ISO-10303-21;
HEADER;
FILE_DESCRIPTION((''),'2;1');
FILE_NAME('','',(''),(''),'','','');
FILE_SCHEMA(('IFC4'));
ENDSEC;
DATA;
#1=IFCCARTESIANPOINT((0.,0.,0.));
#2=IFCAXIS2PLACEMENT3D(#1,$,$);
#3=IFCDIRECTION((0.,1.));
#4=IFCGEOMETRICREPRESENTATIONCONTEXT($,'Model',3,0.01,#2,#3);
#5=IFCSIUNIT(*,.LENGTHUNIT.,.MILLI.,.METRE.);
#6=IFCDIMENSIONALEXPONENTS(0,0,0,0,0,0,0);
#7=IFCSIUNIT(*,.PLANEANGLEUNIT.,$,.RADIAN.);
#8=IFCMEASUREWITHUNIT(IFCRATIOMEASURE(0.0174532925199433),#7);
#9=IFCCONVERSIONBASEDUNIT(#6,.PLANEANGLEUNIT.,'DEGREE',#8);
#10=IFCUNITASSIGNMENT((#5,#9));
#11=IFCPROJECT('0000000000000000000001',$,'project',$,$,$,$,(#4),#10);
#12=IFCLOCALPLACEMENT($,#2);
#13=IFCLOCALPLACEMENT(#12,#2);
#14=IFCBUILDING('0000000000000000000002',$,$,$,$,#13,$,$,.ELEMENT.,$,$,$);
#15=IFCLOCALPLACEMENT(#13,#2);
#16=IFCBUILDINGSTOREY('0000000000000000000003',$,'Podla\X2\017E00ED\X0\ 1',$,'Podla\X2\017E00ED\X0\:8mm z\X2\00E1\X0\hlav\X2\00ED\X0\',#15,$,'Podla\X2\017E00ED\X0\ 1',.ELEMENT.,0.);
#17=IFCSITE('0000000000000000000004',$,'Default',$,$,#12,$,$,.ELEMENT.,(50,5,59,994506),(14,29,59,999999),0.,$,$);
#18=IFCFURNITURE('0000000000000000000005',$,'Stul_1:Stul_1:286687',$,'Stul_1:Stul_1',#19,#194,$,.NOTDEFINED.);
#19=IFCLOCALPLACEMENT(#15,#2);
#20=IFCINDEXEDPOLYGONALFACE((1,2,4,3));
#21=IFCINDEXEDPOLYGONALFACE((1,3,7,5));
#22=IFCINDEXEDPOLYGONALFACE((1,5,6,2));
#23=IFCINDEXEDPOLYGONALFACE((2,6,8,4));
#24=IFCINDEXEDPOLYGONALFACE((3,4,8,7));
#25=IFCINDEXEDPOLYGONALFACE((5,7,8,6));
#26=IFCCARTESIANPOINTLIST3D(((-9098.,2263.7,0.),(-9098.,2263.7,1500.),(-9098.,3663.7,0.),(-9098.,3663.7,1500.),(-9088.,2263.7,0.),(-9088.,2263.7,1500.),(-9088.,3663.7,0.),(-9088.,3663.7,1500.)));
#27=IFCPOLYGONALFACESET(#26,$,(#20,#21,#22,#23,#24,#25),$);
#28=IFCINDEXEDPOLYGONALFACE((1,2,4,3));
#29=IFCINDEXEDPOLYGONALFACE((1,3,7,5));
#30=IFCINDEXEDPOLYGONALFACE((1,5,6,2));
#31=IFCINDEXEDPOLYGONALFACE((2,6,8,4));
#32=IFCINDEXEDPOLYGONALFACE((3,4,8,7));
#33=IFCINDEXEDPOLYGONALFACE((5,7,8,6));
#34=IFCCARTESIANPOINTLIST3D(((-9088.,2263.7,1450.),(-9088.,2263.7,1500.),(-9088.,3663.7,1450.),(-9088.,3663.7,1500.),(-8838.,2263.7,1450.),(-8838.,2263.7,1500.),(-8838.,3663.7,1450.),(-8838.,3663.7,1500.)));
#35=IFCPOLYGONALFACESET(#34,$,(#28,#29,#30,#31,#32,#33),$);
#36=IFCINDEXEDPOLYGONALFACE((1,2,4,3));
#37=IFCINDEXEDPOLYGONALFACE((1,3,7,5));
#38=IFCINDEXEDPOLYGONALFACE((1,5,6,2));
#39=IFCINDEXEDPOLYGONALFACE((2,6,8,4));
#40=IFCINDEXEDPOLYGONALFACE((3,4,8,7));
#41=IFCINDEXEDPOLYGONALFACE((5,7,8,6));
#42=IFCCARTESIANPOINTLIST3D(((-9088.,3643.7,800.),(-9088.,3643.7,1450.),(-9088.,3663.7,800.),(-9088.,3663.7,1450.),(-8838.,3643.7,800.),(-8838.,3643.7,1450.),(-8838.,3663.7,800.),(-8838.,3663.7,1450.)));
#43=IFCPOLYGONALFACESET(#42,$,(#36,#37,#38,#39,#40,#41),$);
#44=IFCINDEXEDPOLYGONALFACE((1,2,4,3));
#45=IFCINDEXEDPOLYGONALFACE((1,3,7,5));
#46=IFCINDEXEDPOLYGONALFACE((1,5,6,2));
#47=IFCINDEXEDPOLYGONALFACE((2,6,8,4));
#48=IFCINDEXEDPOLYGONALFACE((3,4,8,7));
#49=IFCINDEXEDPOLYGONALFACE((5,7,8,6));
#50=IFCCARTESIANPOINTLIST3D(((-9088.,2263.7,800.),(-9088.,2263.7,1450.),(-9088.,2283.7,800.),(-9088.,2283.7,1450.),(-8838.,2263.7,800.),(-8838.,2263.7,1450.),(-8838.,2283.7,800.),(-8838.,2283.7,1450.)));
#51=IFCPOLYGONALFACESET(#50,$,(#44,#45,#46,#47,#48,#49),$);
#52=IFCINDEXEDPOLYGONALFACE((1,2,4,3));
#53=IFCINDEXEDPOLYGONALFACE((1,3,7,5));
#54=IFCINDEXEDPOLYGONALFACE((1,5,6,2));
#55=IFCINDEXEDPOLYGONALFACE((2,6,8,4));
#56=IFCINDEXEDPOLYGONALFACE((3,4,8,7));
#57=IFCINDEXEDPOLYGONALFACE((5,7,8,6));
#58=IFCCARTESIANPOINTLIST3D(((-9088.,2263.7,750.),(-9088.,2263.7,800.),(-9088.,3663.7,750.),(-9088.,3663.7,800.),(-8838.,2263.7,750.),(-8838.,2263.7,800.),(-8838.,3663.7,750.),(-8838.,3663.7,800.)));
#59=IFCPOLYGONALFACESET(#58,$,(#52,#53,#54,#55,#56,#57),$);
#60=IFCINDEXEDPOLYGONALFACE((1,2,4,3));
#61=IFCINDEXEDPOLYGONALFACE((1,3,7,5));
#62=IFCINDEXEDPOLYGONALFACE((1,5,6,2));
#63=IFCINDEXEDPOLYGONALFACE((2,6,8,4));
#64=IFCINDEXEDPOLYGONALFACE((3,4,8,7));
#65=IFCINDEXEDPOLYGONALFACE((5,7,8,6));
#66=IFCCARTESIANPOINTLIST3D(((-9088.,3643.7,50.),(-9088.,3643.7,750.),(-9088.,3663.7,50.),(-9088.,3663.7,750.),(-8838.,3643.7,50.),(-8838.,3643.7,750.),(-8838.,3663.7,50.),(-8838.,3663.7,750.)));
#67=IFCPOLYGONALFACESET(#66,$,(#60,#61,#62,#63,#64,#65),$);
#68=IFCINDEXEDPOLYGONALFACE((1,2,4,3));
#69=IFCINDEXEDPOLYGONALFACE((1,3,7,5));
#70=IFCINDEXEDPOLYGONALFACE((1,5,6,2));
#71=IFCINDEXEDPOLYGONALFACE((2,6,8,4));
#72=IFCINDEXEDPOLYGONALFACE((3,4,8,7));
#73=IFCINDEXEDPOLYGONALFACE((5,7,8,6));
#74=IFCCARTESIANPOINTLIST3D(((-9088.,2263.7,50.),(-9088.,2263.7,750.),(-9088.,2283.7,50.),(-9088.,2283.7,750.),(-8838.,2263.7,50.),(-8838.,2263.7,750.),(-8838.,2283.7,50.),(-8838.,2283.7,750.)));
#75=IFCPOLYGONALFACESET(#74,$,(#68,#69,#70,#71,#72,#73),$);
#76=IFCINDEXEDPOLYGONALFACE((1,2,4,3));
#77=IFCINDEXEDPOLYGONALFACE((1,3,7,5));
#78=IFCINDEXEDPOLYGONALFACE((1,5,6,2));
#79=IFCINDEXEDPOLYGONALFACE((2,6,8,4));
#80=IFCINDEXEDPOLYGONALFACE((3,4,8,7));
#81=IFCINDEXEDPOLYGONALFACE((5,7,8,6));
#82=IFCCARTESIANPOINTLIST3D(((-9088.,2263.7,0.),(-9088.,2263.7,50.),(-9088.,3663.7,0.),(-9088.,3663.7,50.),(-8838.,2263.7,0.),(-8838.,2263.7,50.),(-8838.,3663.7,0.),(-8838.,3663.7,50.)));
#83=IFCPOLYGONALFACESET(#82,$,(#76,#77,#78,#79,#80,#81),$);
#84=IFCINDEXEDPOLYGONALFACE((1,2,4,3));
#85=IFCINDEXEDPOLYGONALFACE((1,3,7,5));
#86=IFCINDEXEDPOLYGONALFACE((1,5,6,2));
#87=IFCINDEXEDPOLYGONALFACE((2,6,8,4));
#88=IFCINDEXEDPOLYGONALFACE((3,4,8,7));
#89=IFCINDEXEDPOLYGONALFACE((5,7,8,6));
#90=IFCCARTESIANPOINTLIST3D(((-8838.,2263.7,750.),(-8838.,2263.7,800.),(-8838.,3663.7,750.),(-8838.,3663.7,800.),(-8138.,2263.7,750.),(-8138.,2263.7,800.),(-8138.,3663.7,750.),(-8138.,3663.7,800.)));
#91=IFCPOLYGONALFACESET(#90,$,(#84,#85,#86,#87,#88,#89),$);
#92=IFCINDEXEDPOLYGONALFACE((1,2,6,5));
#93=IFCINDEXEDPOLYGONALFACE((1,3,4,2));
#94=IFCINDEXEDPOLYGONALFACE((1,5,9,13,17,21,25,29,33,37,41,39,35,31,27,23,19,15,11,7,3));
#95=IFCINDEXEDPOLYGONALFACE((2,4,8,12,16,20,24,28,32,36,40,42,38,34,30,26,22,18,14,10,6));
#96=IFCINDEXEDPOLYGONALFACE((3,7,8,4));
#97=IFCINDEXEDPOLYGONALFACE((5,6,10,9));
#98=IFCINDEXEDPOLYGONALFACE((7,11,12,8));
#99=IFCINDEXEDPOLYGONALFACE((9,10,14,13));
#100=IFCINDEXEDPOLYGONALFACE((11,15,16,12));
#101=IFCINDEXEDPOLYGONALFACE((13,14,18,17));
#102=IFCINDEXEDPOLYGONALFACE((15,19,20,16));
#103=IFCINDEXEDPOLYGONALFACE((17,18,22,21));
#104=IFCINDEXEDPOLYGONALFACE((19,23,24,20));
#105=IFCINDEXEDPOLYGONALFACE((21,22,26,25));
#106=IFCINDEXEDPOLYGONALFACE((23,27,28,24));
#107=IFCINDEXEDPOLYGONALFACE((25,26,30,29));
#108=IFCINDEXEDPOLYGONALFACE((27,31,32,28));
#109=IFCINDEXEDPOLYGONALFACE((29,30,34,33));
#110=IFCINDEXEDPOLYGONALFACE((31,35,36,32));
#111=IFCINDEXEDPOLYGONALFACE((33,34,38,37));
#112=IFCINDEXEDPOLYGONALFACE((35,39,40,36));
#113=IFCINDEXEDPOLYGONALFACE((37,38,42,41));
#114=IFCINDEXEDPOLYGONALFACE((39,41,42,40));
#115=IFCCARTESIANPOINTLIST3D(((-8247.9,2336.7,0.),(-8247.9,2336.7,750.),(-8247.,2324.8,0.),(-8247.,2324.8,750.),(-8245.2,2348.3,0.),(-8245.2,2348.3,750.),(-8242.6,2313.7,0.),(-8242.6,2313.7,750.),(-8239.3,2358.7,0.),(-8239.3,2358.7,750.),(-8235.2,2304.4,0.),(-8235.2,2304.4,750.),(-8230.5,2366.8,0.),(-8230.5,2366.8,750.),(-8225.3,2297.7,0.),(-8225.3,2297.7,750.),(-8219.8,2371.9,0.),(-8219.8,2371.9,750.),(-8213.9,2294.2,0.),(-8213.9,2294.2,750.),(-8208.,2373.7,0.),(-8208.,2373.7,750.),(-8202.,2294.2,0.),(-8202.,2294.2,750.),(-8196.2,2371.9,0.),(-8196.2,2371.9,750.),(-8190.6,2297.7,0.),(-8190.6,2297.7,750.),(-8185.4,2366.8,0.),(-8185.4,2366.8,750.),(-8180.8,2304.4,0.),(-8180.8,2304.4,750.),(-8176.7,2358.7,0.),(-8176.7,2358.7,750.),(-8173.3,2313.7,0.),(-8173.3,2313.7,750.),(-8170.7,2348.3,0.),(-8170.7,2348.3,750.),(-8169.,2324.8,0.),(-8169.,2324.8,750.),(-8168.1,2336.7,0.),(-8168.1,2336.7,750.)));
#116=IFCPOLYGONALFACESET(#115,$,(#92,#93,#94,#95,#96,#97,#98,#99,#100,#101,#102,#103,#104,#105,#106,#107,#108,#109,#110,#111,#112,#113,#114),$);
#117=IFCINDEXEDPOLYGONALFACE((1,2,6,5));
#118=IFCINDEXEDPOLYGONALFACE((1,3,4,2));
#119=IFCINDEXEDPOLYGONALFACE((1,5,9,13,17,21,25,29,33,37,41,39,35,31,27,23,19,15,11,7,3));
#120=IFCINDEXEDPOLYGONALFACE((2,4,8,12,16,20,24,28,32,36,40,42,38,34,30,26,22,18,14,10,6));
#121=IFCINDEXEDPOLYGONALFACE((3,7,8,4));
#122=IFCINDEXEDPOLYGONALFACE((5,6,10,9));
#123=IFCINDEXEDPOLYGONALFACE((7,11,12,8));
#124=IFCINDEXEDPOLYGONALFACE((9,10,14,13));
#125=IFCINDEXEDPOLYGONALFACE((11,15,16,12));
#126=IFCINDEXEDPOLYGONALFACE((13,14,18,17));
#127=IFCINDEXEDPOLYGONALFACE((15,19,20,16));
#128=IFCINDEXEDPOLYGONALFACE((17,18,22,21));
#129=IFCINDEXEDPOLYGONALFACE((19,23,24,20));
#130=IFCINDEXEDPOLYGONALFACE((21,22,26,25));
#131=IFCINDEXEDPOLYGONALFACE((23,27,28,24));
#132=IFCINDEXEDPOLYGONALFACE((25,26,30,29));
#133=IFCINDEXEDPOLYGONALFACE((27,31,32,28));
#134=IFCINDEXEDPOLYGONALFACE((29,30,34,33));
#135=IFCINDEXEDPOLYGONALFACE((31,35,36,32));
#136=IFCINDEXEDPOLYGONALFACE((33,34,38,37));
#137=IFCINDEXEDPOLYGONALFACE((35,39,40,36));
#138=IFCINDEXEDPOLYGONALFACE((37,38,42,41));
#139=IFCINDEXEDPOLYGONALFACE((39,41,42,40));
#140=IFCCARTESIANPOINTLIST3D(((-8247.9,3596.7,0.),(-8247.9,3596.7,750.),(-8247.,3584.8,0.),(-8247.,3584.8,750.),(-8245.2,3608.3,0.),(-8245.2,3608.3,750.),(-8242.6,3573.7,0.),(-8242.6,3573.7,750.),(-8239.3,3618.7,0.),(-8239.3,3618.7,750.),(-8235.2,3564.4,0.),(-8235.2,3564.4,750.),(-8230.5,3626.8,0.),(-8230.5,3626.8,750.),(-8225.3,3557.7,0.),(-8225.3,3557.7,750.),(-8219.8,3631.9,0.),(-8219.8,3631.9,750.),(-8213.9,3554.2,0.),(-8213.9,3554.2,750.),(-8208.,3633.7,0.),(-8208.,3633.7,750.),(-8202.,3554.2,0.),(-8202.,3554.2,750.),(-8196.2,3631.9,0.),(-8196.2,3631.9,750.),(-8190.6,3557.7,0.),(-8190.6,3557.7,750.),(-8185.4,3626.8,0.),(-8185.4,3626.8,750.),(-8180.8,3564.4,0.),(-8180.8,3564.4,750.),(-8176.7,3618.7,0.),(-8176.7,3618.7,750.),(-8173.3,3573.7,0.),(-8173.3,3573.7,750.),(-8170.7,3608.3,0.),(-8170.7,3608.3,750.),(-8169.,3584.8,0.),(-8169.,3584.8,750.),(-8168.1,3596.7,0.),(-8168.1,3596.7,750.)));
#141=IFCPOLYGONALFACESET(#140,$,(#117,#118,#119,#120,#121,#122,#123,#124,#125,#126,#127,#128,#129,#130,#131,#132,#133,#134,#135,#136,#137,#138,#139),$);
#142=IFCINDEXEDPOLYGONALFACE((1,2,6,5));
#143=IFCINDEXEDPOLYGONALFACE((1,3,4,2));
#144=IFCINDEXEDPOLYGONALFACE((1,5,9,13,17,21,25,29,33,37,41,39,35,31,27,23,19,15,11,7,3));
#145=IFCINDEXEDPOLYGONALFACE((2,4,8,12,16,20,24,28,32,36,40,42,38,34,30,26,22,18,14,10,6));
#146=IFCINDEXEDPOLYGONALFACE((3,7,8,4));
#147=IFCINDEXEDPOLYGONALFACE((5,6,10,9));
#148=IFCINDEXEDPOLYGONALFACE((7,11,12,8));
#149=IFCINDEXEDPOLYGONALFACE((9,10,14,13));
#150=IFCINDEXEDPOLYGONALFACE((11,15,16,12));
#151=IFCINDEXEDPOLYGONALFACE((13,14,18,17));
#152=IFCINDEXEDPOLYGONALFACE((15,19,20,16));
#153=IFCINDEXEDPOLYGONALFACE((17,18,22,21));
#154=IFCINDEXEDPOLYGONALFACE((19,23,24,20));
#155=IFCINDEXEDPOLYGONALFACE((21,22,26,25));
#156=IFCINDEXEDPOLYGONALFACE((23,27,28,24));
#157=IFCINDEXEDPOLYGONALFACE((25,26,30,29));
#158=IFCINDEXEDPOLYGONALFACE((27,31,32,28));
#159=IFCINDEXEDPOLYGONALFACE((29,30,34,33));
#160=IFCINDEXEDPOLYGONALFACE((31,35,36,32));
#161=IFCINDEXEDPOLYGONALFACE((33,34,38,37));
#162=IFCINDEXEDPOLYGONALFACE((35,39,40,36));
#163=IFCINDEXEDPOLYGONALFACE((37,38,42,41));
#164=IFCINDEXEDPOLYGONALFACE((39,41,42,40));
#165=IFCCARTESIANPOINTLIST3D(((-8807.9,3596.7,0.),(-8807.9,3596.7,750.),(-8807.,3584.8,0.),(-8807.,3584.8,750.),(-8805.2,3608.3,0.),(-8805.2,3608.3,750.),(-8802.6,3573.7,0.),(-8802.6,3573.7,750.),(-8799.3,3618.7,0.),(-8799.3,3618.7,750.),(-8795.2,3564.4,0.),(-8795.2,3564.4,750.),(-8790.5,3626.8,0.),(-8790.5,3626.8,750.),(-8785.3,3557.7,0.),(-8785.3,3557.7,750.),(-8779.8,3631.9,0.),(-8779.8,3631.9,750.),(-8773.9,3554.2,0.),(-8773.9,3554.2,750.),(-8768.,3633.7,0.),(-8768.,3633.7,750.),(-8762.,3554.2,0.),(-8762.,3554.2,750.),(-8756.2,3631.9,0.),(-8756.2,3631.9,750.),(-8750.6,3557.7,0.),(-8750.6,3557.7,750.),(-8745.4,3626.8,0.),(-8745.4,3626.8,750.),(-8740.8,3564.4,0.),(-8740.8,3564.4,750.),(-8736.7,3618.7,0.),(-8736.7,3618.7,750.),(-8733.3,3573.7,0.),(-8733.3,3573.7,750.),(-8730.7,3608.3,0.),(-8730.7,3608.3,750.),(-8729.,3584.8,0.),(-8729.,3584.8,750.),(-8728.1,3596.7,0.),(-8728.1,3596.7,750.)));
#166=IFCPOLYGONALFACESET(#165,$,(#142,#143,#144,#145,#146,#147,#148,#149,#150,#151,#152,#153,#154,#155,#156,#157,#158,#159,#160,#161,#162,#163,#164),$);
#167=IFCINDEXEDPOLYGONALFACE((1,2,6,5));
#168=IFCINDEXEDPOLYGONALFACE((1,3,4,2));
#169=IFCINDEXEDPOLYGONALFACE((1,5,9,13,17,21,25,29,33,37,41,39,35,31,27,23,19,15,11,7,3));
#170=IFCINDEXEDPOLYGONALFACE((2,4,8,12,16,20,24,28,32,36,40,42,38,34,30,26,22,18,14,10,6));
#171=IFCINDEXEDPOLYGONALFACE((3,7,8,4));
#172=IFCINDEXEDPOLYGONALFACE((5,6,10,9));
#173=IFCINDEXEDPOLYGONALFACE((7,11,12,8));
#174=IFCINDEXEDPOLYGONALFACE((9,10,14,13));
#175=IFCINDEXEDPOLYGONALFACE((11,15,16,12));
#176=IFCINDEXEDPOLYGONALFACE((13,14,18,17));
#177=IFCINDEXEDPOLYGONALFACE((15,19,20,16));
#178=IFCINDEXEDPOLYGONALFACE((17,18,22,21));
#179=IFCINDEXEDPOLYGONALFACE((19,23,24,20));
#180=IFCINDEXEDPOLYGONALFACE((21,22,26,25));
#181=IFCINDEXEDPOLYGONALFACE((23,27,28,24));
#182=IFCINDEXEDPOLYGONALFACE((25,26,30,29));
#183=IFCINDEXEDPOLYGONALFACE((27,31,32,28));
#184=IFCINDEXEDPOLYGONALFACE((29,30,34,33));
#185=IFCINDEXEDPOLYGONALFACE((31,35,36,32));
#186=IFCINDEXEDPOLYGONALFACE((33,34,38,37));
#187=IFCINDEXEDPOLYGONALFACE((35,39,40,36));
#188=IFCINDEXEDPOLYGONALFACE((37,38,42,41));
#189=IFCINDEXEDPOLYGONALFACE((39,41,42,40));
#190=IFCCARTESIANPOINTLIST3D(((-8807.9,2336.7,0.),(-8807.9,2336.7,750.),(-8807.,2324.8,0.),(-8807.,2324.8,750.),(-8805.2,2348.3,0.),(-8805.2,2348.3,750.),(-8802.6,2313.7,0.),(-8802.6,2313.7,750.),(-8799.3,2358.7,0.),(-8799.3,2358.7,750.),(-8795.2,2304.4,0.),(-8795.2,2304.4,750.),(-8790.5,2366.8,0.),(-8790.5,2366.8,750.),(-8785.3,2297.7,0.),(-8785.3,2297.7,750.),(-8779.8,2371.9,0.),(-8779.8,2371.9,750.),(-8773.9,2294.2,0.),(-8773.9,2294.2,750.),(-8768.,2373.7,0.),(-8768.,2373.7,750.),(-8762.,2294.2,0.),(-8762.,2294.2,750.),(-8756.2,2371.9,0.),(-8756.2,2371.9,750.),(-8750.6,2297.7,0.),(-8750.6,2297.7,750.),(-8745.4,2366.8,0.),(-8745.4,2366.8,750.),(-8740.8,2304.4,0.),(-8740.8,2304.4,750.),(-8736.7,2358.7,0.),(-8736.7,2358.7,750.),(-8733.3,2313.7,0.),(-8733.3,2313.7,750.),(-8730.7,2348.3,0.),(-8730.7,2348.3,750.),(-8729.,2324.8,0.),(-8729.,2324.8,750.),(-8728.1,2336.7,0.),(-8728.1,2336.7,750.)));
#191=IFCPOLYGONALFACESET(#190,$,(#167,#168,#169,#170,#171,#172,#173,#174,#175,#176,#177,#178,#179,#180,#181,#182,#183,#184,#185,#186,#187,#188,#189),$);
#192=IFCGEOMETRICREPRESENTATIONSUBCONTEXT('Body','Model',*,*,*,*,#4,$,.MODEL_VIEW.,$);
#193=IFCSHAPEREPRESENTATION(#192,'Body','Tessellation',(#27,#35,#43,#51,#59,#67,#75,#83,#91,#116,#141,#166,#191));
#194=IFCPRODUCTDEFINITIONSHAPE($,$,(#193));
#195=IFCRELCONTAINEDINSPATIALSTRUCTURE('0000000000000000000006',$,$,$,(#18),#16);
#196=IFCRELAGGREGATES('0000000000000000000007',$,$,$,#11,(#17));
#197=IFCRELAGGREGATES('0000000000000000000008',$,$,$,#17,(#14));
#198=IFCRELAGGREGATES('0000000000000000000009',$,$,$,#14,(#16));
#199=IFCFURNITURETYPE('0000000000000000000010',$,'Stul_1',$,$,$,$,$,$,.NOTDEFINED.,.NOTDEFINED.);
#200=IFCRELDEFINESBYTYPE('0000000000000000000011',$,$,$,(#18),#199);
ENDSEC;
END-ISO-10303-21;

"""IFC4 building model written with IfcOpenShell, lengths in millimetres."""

from ifc_helpers import new_model, entity, si_unit, converted_unit, direction, frame, frame_2d, origin, origin_2d_with_axis, place, context, subcontext, project, spatial, rectangle, circle, extrude, source, transform, mapped, type_object, type_shapes, element, save


model = new_model("IFC4")

# Units and contexts
model_context = context("Model", 3, precision=0.01, world=origin(), true_north=direction((0.0, 1.0)))
body_context = subcontext(model_context, "Body", "Model", "MODEL_VIEW")
ifc_project = project(units=[si_unit("LENGTHUNIT", "METRE", prefix="MILLI"), converted_unit("PLANEANGLEUNIT", "DEGREE", entity("IfcRatioMeasure", 0.0174532925199433), si_unit("PLANEANGLEUNIT", "RADIAN"), dimensions=[0, 0, 0, 0, 0, 0, 0])], contexts=[model_context])

# Site, building, storey
site_placement = place(None, origin())
site = spatial("IfcSite", under=ifc_project, at=site_placement, Name="Default", CompositionType="ELEMENT", RefLatitude=(50, 5, 59, 994506), RefLongitude=(14, 29, 59, 999999), RefElevation=0.0)
building_placement = place(site_placement, origin())
building = spatial("IfcBuilding", under=site, at=building_placement, CompositionType="ELEMENT")
storey_placement = place(building_placement, origin())
storey = spatial("IfcBuildingStorey", under=building, at=storey_placement, Name="Podlaží 1", ObjectType="Podlaží:8mm záhlaví", LongName="Podlaží 1", CompositionType="ELEMENT", Elevation=0.0)

# Furniture
furniture_type = type_object("IfcFurnitureType", Name="Stul_1", AssemblyPlace="NOTDEFINED", PredefinedType="NOTDEFINED")
shared_shape_1 = source(origin(), body_context, "Body", "SweptSolid", [
    extrude(rectangle(XDim=1400.0, YDim=10.0, at=origin_2d_with_axis()), frame((0.0, 605.0, 0.0), z_axis=(0.0, 0.0, 1.0), x_axis=(-1.0, 0.0, 0.0)), (0.0, 0.0, 1.0), 1500.0),
    extrude(rectangle(XDim=1400.0, YDim=250.0, at=frame_2d((0.0, 0.0), x_axis=(1.0, 0.0))), frame((0.0, 475.0, 1450.0), z_axis=(0.0, 0.0, 1.0), x_axis=(-1.0, 0.0, 0.0)), (0.0, 0.0, 1.0), 50.0),
    extrude(rectangle(XDim=20.0, YDim=250.0, at=origin_2d_with_axis()), frame((690.0, 475.0, 800.0), z_axis=(0.0, 0.0, 1.0), x_axis=(-1.0, 0.0, 0.0)), (0.0, 0.0, 1.0), 650.0),
    extrude(rectangle(XDim=20.0, YDim=250.0, at=frame_2d((0.0, 0.0), x_axis=(1.0, 0.0))), frame((-690.0, 475.0, 800.0), z_axis=(0.0, 0.0, 1.0), x_axis=(-1.0, 0.0, 0.0)), (0.0, 0.0, 1.0), 650.0),
    extrude(rectangle(XDim=1400.0, YDim=250.0, at=origin_2d_with_axis()), frame((0.0, 475.0, 750.0), z_axis=(0.0, 0.0, 1.0), x_axis=(-1.0, 0.0, 0.0)), (0.0, 0.0, 1.0), 50.0),
    extrude(rectangle(XDim=20.0, YDim=250.0, at=origin_2d_with_axis()), frame((690.0, 475.0, 50.0), z_axis=(0.0, 0.0, 1.0), x_axis=(-1.0, 0.0, 0.0)), (0.0, 0.0, 1.0), 700.0),
    extrude(rectangle(XDim=20.0, YDim=250.0, at=frame_2d((0.0, 0.0), x_axis=(1.0, 0.0))), frame((-690.0, 475.0, 50.0), z_axis=(0.0, 0.0, 1.0), x_axis=(-1.0, 0.0, 0.0)), (0.0, 0.0, 1.0), 700.0),
    extrude(rectangle(XDim=1400.0, YDim=250.0, at=origin_2d_with_axis()), frame((0.0, 475.0, 0.0), z_axis=(0.0, 0.0, 1.0), x_axis=(-1.0, 0.0, 0.0)), (0.0, 0.0, 1.0), 50.0),
    extrude(rectangle(XDim=1400.0, YDim=700.0, at=origin_2d_with_axis()), frame((0.0, 0.0, 750.0), z_axis=(0.0, 0.0, 1.0), x_axis=(-1.0, 0.0, 0.0)), (0.0, 0.0, 1.0), 50.0),
    extrude(circle(Radius=40.0, at=frame_2d((0.0, 0.0), x_axis=(1.0, 0.0))), frame((-630.0, -280.0, 0.0)), (0.0, 0.0, 1.0), 750.0),
    extrude(circle(Radius=40.0, at=frame_2d((0.0, 0.0), x_axis=(1.0, 0.0))), frame((630.0, -280.0, 0.0)), (0.0, 0.0, 1.0), 750.0),
    extrude(circle(Radius=40.0, at=frame_2d((0.0, 0.0), x_axis=(1.0, 0.0))), frame((630.0, 280.0, 0.0)), (0.0, 0.0, 1.0), 750.0),
    extrude(circle(Radius=40.0, at=frame_2d((0.0, 0.0), x_axis=(1.0, 0.0))), frame((-630.0, 280.0, 0.0)), (0.0, 0.0, 1.0), 750.0),
])
type_shapes(furniture_type, [shared_shape_1])
for number, where, z_axis, x_axis, name in (
    (1, (-8488.0, 2963.7, 0.0), (0.0, 0.0, 1.0), (0.0, 1.0, 0.0), "Stul_1:Stul_1:286687"),
):
    element("IfcFurniture", number, at=place(storey_placement, frame(where, z_axis=z_axis, x_axis=x_axis)), inside=storey, type_object=furniture_type, Name=name, ObjectType="Stul_1:Stul_1", PredefinedType="NOTDEFINED", context=body_context, shape_type="MappedRepresentation", body=[
        mapped(shared_shape_1, transform((0.0, 0.0, 0.0), scale=1.0)),
    ])

save(model, "model.ifc")
